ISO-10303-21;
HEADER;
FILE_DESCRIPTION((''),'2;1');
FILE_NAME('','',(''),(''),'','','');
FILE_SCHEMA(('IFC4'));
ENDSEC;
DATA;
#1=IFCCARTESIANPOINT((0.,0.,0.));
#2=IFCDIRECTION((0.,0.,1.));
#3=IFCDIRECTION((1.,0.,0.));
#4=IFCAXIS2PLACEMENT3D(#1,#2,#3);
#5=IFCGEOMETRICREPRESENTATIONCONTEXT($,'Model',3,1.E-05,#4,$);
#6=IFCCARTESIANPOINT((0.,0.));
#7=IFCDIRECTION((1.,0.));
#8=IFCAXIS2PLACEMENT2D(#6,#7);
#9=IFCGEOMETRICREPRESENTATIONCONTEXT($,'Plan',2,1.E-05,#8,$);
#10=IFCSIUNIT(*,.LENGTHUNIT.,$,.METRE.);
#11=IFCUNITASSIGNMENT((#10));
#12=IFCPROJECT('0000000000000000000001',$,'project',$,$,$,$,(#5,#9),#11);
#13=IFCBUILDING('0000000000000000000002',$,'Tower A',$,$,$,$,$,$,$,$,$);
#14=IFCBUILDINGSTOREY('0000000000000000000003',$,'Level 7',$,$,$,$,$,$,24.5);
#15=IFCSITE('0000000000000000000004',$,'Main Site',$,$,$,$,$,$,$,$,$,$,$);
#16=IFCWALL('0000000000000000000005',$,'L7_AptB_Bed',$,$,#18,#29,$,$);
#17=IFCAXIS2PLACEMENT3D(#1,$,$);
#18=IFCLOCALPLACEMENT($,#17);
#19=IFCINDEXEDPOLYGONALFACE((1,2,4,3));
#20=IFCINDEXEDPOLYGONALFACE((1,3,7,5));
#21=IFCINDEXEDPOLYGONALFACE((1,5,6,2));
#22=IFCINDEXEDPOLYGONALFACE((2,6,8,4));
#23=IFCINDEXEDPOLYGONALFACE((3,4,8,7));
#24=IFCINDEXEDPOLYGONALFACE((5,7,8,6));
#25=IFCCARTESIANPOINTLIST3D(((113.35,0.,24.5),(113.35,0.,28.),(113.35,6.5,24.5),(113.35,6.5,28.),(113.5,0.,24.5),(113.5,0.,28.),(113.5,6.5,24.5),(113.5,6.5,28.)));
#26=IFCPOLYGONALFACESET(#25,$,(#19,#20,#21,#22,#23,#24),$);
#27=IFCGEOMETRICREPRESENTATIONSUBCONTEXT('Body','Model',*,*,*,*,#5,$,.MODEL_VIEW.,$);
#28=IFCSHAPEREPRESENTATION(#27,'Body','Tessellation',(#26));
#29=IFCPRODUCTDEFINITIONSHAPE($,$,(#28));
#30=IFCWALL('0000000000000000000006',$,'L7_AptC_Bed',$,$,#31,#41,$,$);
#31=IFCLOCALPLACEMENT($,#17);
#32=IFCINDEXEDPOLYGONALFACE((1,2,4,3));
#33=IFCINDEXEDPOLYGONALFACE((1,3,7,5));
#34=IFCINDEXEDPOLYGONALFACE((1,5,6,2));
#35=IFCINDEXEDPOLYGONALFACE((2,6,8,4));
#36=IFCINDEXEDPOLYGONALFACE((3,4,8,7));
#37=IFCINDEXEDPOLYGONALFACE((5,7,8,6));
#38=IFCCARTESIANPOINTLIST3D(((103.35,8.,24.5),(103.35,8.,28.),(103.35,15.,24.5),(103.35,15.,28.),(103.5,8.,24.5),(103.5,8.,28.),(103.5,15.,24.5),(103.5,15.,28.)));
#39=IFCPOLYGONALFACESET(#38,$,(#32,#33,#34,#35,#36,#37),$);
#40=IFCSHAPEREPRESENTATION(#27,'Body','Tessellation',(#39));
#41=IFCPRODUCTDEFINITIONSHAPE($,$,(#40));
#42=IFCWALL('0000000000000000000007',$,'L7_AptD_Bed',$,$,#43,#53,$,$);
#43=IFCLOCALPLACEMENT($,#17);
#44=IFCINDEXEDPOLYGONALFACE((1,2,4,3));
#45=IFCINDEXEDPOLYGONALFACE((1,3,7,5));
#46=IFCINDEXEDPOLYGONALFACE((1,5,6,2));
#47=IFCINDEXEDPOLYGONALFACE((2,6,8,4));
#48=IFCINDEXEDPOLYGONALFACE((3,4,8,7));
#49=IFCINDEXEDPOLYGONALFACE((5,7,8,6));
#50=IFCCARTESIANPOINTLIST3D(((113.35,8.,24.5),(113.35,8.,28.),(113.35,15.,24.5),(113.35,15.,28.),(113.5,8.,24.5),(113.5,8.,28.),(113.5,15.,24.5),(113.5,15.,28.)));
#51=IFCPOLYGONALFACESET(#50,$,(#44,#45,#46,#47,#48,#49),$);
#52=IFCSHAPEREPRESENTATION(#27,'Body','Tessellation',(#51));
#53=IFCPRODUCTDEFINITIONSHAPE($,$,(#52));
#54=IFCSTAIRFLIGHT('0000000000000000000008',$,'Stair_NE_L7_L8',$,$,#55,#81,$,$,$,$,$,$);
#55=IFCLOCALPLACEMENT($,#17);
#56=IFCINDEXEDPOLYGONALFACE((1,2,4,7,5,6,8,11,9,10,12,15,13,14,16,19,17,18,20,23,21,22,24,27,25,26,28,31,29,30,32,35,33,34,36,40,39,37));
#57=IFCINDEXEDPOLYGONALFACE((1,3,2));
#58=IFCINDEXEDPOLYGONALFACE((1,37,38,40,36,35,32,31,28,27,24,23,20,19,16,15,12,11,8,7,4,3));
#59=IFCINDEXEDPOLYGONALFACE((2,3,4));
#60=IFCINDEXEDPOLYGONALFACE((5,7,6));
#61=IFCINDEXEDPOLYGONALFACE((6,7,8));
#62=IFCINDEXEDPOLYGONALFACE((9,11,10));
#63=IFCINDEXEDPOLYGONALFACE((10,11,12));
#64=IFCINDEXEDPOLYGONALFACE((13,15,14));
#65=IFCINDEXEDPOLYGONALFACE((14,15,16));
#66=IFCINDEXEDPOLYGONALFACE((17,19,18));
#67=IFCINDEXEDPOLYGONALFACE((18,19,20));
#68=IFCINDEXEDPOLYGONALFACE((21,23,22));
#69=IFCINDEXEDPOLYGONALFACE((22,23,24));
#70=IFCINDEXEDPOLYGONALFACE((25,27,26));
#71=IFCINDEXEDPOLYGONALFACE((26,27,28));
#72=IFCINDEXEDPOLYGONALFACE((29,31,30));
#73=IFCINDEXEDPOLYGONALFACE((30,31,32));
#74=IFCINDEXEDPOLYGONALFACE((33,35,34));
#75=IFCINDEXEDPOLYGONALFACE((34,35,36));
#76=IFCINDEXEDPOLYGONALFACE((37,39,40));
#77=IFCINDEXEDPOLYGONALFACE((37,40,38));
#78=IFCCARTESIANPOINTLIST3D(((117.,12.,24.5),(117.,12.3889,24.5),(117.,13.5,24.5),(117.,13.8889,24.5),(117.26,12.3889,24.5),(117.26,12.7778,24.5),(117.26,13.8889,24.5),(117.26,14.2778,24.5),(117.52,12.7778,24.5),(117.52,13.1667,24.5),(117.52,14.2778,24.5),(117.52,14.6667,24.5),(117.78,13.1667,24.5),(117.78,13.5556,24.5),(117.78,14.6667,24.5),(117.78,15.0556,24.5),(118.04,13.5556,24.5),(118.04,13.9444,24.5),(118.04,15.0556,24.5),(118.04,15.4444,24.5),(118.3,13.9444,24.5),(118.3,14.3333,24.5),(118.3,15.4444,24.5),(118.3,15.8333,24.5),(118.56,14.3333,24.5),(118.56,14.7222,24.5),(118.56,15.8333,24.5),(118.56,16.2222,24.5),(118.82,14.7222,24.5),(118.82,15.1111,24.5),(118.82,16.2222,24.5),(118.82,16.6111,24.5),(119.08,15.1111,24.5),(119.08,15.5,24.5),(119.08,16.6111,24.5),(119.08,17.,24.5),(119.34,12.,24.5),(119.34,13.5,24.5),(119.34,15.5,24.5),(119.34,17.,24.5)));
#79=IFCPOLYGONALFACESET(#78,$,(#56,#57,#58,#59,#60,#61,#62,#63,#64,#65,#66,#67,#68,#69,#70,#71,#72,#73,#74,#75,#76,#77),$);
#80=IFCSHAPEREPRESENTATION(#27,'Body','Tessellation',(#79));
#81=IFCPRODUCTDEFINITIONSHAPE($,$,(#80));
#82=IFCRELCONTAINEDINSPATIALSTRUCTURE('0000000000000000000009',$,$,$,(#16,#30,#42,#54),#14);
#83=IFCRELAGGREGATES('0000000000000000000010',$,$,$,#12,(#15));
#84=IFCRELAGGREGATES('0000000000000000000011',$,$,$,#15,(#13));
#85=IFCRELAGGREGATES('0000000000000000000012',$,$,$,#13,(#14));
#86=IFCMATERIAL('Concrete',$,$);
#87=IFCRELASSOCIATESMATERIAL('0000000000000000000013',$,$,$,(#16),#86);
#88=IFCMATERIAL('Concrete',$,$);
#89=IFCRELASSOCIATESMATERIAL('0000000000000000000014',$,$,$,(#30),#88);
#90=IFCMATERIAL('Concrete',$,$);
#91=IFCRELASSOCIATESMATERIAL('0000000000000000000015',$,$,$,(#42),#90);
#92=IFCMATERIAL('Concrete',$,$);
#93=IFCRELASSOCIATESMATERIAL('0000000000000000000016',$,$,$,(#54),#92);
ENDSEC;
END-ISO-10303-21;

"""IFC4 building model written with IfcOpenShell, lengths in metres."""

from ifc_helpers import new_model, si_unit, frame, origin_with_axes, origin_2d_with_axis, place, context, subcontext, project, spatial, line, indexed_curve, outline, extrude, material, element, save


model = new_model("IFC4")

# Units and contexts
model_context = context("Model", 3, precision=1e-05, world=origin_with_axes())
plan_context = context("Plan", 2, precision=1e-05, world=origin_2d_with_axis())
body_context = subcontext(model_context, "Body", "Model", "MODEL_VIEW")
ifc_project = project(units=[si_unit("LENGTHUNIT", "METRE")], contexts=[model_context, plan_context])

# Site, building, storey
site = spatial("IfcSite", under=ifc_project, Name="Main Site")
building = spatial("IfcBuilding", under=site, Name="Tower A")
storey = spatial("IfcBuildingStorey", under=building, Name="Level 7", Elevation=24.5)

# Walls
ifc_material_1 = material(Name="Concrete")
wall_1_placement = place(None, frame((113.5, 0.0, 24.5), z_axis=(0.0, 0.0, 1.0), x_axis=(0.0, 1.0, 0.0)))
element("IfcWall", 1, at=wall_1_placement, inside=storey, material=ifc_material_1, Name="L7_AptB_Bed", context=body_context, shape_type="SweptSolid", body=[
    extrude(outline(indexed_curve([(0.0, 0.0), (0.0, 0.15), (6.5, 0.15), (6.5, 0.0), (0.0, 0.0)], self_intersect=False)), origin_with_axes(), (0.0, 0.0, 1.0), 3.5),
])
ifc_material_2 = material(Name="Concrete")
wall_2_placement = place(None, frame((103.5, 8.0, 24.5), z_axis=(0.0, 0.0, 1.0), x_axis=(0.0, 1.0, 0.0)))
element("IfcWall", 2, at=wall_2_placement, inside=storey, material=ifc_material_2, Name="L7_AptC_Bed", context=body_context, shape_type="SweptSolid", body=[
    extrude(outline(indexed_curve([(0.0, 0.0), (0.0, 0.15), (7.0, 0.15), (7.0, 0.0), (0.0, 0.0)], self_intersect=False)), origin_with_axes(), (0.0, 0.0, 1.0), 3.5),
])
ifc_material_3 = material(Name="Concrete")
wall_3_placement = place(None, frame((113.5, 8.0, 24.5), z_axis=(0.0, 0.0, 1.0), x_axis=(0.0, 1.0, 0.0)))
element("IfcWall", 3, at=wall_3_placement, inside=storey, material=ifc_material_3, Name="L7_AptD_Bed", context=body_context, shape_type="SweptSolid", body=[
    extrude(outline(indexed_curve([(0.0, 0.0), (0.0, 0.15), (7.0, 0.15), (7.0, 0.0), (0.0, 0.0)], self_intersect=False)), origin_with_axes(), (0.0, 0.0, 1.0), 3.5),
])

# Stair flight
ifc_material_4 = material(Name="Concrete")
stair_flight_placement = place(None, frame((117.0, 12.0, 24.5), z_axis=(0.0, 0.0, 1.0), x_axis=(1.0, 0.0, 0.0)))
element("IfcStairFlight", 4, at=stair_flight_placement, inside=storey, material=ifc_material_4, Name="Stair_NE_L7_L8", context=body_context, shape_type="SweptSolid", body=[
    extrude(outline(indexed_curve([(0.0, 0.0), (0.0, 0.3889), (0.26, 0.3889), (0.26, 0.7778), (0.52, 0.7778), (0.52, 1.1667), (0.78, 1.1667), (0.78, 1.5556), (1.04, 1.5556), (1.04, 1.9444), (1.3, 1.9444), (1.3, 2.3333), (1.56, 2.3333), (1.56, 2.7222), (1.82, 2.7222), (1.82, 3.1111), (2.08, 3.1111), (2.08, 3.5), (2.34, 3.5), (2.34, 0.0)], segments=[line(1, 2, 3, 4, 5, 6, 7, 8, 9, 10, 11, 12, 13, 14, 15, 16, 17, 18, 19, 20, 1)])), origin_with_axes(), (0.0, 1.0, 0.0), 1.5),
])

save(model, "model.ifc")
